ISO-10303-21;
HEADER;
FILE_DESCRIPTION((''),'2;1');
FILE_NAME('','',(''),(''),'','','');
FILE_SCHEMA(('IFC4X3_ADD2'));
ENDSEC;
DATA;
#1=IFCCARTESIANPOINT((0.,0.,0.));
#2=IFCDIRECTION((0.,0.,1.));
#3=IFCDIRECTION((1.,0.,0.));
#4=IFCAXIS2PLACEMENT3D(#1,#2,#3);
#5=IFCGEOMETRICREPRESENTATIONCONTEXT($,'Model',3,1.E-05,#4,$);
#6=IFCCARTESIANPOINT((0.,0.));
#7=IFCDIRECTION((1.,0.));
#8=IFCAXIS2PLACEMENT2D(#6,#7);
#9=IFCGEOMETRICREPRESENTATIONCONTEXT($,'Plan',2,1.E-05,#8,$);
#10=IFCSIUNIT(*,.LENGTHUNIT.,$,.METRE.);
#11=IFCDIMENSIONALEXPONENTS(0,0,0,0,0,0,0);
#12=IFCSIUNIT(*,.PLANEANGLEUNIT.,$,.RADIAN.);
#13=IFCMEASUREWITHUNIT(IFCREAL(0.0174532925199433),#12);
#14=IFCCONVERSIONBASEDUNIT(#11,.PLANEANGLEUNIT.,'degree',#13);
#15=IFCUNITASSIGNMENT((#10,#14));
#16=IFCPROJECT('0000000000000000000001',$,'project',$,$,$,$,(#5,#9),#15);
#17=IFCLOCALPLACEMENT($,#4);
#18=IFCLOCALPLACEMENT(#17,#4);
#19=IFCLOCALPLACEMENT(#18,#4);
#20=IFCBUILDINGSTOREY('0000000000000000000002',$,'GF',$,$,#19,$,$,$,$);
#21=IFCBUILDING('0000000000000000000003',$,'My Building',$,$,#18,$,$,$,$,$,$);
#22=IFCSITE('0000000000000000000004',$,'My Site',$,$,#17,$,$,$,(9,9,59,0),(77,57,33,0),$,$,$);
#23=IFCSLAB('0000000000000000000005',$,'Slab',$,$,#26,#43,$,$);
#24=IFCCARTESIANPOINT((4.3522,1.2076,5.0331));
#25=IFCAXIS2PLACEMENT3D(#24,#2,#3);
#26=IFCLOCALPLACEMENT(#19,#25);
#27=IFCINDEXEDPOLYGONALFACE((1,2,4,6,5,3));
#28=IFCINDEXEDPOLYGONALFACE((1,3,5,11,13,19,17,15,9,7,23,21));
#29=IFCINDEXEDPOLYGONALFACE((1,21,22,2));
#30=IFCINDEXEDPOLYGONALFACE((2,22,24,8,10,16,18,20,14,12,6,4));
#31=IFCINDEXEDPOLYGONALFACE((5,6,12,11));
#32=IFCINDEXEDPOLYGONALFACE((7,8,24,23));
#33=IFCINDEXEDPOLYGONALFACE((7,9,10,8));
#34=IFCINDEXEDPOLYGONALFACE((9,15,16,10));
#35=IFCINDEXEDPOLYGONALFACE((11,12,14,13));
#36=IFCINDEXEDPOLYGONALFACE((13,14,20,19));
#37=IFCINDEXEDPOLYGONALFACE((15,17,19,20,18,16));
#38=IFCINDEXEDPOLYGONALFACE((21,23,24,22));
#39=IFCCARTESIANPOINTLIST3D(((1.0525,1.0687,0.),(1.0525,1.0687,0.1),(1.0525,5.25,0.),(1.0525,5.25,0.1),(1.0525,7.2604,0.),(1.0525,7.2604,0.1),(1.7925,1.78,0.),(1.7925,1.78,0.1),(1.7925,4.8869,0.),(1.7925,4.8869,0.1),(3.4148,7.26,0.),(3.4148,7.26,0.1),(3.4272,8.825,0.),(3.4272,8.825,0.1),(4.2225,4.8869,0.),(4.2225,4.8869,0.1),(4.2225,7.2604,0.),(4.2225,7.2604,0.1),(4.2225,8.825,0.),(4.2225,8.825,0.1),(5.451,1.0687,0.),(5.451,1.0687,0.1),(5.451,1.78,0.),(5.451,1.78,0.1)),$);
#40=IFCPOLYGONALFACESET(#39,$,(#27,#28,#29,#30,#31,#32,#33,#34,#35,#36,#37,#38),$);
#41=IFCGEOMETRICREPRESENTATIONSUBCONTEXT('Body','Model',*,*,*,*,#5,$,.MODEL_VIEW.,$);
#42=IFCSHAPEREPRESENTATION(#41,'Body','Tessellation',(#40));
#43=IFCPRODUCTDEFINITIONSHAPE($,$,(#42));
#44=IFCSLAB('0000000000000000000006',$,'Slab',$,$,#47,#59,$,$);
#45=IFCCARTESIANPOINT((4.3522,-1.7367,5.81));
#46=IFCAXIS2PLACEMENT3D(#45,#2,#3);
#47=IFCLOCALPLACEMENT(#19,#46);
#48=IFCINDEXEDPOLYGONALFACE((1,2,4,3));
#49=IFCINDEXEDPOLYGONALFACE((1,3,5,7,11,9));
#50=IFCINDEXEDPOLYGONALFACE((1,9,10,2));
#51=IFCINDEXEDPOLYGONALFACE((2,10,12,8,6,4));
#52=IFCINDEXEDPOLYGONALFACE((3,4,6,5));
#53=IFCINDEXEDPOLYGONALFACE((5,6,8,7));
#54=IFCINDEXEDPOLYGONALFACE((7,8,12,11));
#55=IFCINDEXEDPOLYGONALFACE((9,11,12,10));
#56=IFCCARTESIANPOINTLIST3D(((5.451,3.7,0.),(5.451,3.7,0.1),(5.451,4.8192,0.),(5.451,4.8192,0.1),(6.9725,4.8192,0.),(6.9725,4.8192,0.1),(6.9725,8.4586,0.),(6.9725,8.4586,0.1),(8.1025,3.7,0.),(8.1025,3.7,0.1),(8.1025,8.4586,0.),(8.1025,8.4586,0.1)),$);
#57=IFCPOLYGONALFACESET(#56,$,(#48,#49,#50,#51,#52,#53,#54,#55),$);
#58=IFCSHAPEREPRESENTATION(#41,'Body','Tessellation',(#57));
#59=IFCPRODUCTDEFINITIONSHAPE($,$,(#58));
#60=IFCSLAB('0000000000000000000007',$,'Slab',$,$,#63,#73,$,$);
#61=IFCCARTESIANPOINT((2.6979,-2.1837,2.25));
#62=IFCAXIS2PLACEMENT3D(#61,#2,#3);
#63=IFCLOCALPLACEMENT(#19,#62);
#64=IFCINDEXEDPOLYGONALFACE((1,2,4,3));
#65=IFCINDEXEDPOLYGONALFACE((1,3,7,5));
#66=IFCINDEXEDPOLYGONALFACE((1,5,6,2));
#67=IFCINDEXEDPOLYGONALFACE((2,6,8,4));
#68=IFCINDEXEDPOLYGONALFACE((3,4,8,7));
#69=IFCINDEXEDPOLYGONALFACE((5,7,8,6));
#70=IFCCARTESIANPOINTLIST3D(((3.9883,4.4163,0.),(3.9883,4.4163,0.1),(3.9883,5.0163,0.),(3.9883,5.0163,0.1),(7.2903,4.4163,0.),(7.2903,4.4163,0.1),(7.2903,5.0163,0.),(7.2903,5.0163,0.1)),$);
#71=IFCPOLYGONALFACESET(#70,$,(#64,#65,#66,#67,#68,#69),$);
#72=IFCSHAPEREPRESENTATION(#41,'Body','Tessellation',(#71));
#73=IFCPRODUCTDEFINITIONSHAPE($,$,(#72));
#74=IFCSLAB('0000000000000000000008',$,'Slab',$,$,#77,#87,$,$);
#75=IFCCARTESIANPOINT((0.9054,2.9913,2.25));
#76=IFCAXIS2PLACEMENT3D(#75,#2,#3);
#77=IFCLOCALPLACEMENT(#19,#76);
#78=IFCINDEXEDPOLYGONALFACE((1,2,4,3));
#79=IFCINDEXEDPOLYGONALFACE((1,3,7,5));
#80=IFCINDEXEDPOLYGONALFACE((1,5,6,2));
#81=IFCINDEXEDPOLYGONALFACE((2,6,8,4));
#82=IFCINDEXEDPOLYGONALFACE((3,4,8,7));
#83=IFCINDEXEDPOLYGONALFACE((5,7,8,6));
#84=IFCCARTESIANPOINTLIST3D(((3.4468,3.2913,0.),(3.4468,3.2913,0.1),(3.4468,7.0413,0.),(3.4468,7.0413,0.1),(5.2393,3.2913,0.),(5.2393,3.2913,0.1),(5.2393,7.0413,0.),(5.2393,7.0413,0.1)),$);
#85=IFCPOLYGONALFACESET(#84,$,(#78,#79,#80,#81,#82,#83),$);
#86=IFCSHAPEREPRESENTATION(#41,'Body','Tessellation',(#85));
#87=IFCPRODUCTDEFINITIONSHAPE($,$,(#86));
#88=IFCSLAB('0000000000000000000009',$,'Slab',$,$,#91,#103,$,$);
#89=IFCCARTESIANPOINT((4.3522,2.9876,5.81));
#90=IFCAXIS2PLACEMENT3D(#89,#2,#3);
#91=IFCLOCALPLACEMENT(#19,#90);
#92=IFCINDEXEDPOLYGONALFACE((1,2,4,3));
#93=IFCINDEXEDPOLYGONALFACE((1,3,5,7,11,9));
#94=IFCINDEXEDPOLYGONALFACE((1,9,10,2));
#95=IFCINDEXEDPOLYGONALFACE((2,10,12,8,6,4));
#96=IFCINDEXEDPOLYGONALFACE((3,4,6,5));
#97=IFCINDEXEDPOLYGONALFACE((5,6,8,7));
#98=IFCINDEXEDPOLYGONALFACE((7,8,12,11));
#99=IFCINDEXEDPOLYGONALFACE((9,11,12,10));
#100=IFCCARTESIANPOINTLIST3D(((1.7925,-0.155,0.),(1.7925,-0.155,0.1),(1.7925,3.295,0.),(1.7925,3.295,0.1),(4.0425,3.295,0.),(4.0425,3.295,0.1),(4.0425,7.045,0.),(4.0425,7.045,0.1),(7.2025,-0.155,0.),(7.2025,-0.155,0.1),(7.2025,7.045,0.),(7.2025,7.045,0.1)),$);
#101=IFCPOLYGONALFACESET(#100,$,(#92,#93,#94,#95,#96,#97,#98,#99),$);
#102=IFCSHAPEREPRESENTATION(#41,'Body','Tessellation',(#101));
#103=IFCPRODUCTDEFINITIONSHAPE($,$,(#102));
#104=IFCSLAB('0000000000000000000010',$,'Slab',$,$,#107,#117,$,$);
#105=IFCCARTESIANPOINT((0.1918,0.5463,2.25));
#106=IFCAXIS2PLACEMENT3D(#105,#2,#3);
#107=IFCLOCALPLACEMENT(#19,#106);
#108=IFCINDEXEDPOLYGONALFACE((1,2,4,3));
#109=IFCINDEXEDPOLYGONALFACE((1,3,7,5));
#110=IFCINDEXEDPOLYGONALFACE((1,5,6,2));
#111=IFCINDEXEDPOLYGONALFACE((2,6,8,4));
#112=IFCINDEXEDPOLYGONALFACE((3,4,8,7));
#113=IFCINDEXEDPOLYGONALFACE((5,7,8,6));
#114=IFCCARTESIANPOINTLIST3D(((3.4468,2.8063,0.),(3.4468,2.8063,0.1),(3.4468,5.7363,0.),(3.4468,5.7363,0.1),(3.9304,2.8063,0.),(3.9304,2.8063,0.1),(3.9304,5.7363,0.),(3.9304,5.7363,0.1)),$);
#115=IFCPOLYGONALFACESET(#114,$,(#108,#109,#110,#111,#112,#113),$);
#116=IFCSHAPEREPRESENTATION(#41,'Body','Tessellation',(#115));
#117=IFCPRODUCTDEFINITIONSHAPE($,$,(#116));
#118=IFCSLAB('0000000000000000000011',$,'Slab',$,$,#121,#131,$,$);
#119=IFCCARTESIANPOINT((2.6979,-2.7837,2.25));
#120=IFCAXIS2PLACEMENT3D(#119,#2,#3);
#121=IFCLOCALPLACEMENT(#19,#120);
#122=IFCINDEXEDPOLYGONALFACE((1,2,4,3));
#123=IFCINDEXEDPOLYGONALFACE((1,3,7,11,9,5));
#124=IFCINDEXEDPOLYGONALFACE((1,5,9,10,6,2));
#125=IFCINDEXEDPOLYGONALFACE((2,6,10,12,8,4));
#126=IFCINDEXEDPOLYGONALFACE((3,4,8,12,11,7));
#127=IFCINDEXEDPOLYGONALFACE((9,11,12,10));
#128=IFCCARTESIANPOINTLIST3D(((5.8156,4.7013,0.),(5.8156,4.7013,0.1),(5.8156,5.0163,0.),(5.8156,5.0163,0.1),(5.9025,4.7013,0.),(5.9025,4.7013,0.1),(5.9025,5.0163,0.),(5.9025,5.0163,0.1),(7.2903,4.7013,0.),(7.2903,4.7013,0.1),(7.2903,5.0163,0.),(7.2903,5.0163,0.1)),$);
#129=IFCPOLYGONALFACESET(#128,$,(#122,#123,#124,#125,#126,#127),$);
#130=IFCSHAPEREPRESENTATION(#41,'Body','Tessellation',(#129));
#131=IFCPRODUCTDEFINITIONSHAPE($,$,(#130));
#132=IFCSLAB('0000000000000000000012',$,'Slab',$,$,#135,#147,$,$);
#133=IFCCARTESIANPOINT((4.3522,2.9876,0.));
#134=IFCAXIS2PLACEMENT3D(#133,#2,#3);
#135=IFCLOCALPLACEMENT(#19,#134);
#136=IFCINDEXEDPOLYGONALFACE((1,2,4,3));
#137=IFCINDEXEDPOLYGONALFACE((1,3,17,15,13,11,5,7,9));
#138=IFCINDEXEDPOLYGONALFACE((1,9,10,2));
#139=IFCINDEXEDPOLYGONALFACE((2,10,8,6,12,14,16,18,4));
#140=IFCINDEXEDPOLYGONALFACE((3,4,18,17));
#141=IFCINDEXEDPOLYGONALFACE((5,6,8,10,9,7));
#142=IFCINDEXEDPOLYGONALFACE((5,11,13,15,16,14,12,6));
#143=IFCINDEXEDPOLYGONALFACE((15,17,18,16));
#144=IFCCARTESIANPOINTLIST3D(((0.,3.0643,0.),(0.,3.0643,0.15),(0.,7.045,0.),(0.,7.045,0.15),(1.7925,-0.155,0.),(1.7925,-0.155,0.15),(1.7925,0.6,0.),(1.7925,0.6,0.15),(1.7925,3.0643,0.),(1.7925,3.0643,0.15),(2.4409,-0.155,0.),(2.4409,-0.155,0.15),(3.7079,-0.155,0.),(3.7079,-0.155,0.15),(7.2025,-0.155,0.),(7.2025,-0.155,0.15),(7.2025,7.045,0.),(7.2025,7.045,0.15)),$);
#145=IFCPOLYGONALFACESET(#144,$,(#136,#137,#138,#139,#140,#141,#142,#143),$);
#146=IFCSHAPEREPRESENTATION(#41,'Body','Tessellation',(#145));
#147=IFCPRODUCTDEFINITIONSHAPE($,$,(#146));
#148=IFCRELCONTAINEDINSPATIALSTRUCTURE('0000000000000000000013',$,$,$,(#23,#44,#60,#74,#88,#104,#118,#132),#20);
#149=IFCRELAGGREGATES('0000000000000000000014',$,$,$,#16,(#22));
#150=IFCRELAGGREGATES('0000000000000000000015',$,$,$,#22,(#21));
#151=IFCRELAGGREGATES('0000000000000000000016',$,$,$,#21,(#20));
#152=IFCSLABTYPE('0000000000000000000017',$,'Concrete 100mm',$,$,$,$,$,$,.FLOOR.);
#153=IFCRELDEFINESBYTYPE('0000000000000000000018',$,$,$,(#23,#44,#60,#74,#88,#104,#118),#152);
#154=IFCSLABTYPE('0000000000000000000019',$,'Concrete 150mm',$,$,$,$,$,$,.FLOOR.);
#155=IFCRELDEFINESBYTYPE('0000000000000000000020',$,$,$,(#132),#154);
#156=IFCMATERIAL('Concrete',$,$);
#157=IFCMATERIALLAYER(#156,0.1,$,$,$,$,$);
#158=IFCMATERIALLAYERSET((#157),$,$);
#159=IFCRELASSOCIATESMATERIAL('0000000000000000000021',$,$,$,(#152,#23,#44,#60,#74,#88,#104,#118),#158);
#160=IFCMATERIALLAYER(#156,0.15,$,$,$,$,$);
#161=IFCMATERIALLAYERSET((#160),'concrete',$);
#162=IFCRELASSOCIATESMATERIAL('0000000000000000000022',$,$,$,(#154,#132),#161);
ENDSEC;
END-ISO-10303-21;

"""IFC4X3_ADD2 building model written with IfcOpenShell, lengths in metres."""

from ifc_helpers import new_model, entity, si_unit, converted_unit, frame, origin_with_axes, origin_2d_with_axis, place, context, subcontext, project, spatial, indexed_curve, outline, extrude, material, layer, layer_set, layer_usage, type_object, element, save


model = new_model("IFC4X3_ADD2")

# Units and contexts
model_context = context("Model", 3, precision=1e-05, world=origin_with_axes())
plan_context = context("Plan", 2, precision=1e-05, world=origin_2d_with_axis())
body_context_1 = subcontext(model_context, "Body", "Model", "MODEL_VIEW")
ifc_project = project(units=[si_unit("LENGTHUNIT", "METRE"), converted_unit("PLANEANGLEUNIT", "degree", entity("IfcReal", 0.0174532925199433), si_unit("PLANEANGLEUNIT", "RADIAN"), dimensions=[0, 0, 0, 0, 0, 0, 0])], contexts=[model_context, plan_context])

# Site, building, storey
site_placement = place(None, origin_with_axes())
site = spatial("IfcSite", under=ifc_project, at=site_placement, Name="My Site", RefLatitude=(9, 9, 59, 0), RefLongitude=(77, 57, 33, 0))
building_placement = place(site_placement, origin_with_axes())
building = spatial("IfcBuilding", under=site, at=building_placement, Name="My Building")
storey_placement = place(building_placement, origin_with_axes())
storey = spatial("IfcBuildingStorey", under=building, at=storey_placement, Name="GF")

# Slabs
ifc_material_1 = material(Name="Concrete")
ifc_layer_1 = layer(ifc_material_1, 0.1)
ifc_layer_set_1 = layer_set([ifc_layer_1])
ifc_layer_usage_1 = layer_usage(ifc_layer_set_1, "AXIS3", "POSITIVE", 0.0)
slab_type_1 = type_object("IfcSlabType", Name="Concrete 100mm", PredefinedType="FLOOR", material=ifc_layer_set_1)
slab_1_placement = place(storey_placement, frame((4.3522, 1.2076, 5.0331), z_axis=(0.0, 0.0, 1.0), x_axis=(1.0, 0.0, 0.0)))
element("IfcSlab", 1, at=slab_1_placement, inside=storey, type_object=slab_type_1, material=ifc_layer_usage_1, Name="Slab", context=body_context_1, shape_type="SweptSolid", body=[
    extrude(outline(indexed_curve([(4.2225, 4.8869), (4.2225, 7.2604), (4.2225, 8.825), (3.4272, 8.825), (3.4148, 7.26), (1.0525, 7.2604), (1.0525, 5.25), (1.0525, 1.0687), (5.451, 1.0687), (5.451, 1.78), (1.7925, 1.78), (1.7925, 4.8869), (4.2225, 4.8869)])), origin_with_axes(), (0.0, 0.0, 1.0), 0.1),
])
ifc_layer_usage_2 = layer_usage(ifc_layer_set_1, "AXIS3", "POSITIVE", 0.0)
slab_2_placement = place(storey_placement, frame((4.3522, -1.7367, 5.81), z_axis=(0.0, 0.0, 1.0), x_axis=(1.0, 0.0, 0.0)))
element("IfcSlab", 2, at=slab_2_placement, inside=storey, type_object=slab_type_1, material=ifc_layer_usage_2, Name="Slab", context=body_context_1, shape_type="SweptSolid", body=[
    extrude(outline(indexed_curve([(8.1025, 3.7), (5.451, 3.7), (5.451, 4.8192), (6.9725, 4.8192), (6.9725, 8.4586), (8.1025, 8.4586), (8.1025, 3.7)])), origin_with_axes(), (0.0, 0.0, 1.0), 0.1),
])
ifc_layer_usage_3 = layer_usage(ifc_layer_set_1, "AXIS3", "POSITIVE", 0.0)
slab_3_placement = place(storey_placement, frame((2.6979, -2.1837, 2.25), z_axis=(0.0, 0.0, 1.0), x_axis=(1.0, 0.0, 0.0)))
element("IfcSlab", 3, at=slab_3_placement, inside=storey, type_object=slab_type_1, material=ifc_layer_usage_3, Name="Slab", context=body_context_1, shape_type="SweptSolid", body=[
    extrude(outline(indexed_curve([(7.2903, 5.0163), (7.2903, 4.4163), (3.9883, 4.4163), (3.9883, 5.0163), (7.2903, 5.0163)])), origin_with_axes(), (0.0, 0.0, 1.0), 0.1),
])
ifc_layer_usage_4 = layer_usage(ifc_layer_set_1, "AXIS3", "POSITIVE", 0.0)
slab_4_placement = place(storey_placement, frame((0.9054, 2.9913, 2.25), z_axis=(0.0, 0.0, 1.0), x_axis=(1.0, 0.0, 0.0)))
element("IfcSlab", 4, at=slab_4_placement, inside=storey, type_object=slab_type_1, material=ifc_layer_usage_4, Name="Slab", context=body_context_1, shape_type="SweptSolid", body=[
    extrude(outline(indexed_curve([(5.2393, 7.0413), (5.2393, 3.2913), (3.4468, 3.2913), (3.4468, 7.0413), (5.2393, 7.0413)])), origin_with_axes(), (0.0, 0.0, 1.0), 0.1),
])
ifc_layer_usage_5 = layer_usage(ifc_layer_set_1, "AXIS3", "POSITIVE", 0.0)
slab_5_placement = place(storey_placement, frame((4.3522, 2.9876, 5.81), z_axis=(0.0, 0.0, 1.0), x_axis=(1.0, 0.0, 0.0)))
element("IfcSlab", 5, at=slab_5_placement, inside=storey, type_object=slab_type_1, material=ifc_layer_usage_5, Name="Slab", context=body_context_1, shape_type="SweptSolid", body=[
    extrude(outline(indexed_curve([(1.7925, 3.295), (1.7925, -0.155), (7.2025, -0.155), (7.2025, 7.045), (4.0425, 7.045), (4.0425, 3.295), (1.7925, 3.295)])), origin_with_axes(), (0.0, 0.0, 1.0), 0.1),
])
ifc_layer_usage_6 = layer_usage(ifc_layer_set_1, "AXIS3", "POSITIVE", 0.0)
slab_6_placement = place(storey_placement, frame((0.1918, 0.5463, 2.25), z_axis=(0.0, 0.0, 1.0), x_axis=(1.0, 0.0, 0.0)))
element("IfcSlab", 6, at=slab_6_placement, inside=storey, type_object=slab_type_1, material=ifc_layer_usage_6, Name="Slab", context=body_context_1, shape_type="SweptSolid", body=[
    extrude(outline(indexed_curve([(3.4468, 5.7363), (3.4468, 2.8063), (3.9304, 2.8063), (3.9304, 5.7363), (3.4468, 5.7363)])), origin_with_axes(), (0.0, 0.0, 1.0), 0.1),
])
ifc_layer_usage_7 = layer_usage(ifc_layer_set_1, "AXIS3", "POSITIVE", 0.0)
slab_7_placement = place(storey_placement, frame((2.6979, -2.7837, 2.25), z_axis=(0.0, 0.0, 1.0), x_axis=(1.0, 0.0, 0.0)))
element("IfcSlab", 7, at=slab_7_placement, inside=storey, type_object=slab_type_1, material=ifc_layer_usage_7, Name="Slab", context=body_context_1, shape_type="SweptSolid", body=[
    extrude(outline(indexed_curve([(5.9025, 4.7013), (7.2903, 4.7013), (7.2903, 5.0163), (5.9025, 5.0163), (5.8156, 5.0163), (5.8156, 4.7013), (5.9025, 4.7013)])), origin_with_axes(), (0.0, 0.0, 1.0), 0.1),
])
ifc_layer_2 = layer(ifc_material_1, 0.15)
ifc_layer_set_2 = layer_set([ifc_layer_2], Name="concrete")
ifc_layer_usage_8 = layer_usage(ifc_layer_set_2, "AXIS3", "POSITIVE", 0.0)
slab_type_2 = type_object("IfcSlabType", Name="Concrete 150mm", PredefinedType="FLOOR", material=ifc_layer_set_2)
slab_8_placement = place(storey_placement, frame((4.3522, 2.9876, 0.0), z_axis=(0.0, 0.0, 1.0), x_axis=(1.0, 0.0, 0.0)))
element("IfcSlab", 8, at=slab_8_placement, inside=storey, type_object=slab_type_2, material=ifc_layer_usage_8, Name="Slab", context=body_context_1, shape_type="SweptSolid", body=[
    extrude(outline(indexed_curve([(3.7079, -0.155), (2.4409, -0.155), (1.7925, -0.155), (1.7925, 0.6), (1.7925, 3.0643), (0.0, 3.0643), (0.0, 7.045), (7.2025, 7.045), (7.2025, -0.155), (3.7079, -0.155)])), None, (0.0, 0.0, 1.0), 0.15),
])

save(model, "model.ifc")
